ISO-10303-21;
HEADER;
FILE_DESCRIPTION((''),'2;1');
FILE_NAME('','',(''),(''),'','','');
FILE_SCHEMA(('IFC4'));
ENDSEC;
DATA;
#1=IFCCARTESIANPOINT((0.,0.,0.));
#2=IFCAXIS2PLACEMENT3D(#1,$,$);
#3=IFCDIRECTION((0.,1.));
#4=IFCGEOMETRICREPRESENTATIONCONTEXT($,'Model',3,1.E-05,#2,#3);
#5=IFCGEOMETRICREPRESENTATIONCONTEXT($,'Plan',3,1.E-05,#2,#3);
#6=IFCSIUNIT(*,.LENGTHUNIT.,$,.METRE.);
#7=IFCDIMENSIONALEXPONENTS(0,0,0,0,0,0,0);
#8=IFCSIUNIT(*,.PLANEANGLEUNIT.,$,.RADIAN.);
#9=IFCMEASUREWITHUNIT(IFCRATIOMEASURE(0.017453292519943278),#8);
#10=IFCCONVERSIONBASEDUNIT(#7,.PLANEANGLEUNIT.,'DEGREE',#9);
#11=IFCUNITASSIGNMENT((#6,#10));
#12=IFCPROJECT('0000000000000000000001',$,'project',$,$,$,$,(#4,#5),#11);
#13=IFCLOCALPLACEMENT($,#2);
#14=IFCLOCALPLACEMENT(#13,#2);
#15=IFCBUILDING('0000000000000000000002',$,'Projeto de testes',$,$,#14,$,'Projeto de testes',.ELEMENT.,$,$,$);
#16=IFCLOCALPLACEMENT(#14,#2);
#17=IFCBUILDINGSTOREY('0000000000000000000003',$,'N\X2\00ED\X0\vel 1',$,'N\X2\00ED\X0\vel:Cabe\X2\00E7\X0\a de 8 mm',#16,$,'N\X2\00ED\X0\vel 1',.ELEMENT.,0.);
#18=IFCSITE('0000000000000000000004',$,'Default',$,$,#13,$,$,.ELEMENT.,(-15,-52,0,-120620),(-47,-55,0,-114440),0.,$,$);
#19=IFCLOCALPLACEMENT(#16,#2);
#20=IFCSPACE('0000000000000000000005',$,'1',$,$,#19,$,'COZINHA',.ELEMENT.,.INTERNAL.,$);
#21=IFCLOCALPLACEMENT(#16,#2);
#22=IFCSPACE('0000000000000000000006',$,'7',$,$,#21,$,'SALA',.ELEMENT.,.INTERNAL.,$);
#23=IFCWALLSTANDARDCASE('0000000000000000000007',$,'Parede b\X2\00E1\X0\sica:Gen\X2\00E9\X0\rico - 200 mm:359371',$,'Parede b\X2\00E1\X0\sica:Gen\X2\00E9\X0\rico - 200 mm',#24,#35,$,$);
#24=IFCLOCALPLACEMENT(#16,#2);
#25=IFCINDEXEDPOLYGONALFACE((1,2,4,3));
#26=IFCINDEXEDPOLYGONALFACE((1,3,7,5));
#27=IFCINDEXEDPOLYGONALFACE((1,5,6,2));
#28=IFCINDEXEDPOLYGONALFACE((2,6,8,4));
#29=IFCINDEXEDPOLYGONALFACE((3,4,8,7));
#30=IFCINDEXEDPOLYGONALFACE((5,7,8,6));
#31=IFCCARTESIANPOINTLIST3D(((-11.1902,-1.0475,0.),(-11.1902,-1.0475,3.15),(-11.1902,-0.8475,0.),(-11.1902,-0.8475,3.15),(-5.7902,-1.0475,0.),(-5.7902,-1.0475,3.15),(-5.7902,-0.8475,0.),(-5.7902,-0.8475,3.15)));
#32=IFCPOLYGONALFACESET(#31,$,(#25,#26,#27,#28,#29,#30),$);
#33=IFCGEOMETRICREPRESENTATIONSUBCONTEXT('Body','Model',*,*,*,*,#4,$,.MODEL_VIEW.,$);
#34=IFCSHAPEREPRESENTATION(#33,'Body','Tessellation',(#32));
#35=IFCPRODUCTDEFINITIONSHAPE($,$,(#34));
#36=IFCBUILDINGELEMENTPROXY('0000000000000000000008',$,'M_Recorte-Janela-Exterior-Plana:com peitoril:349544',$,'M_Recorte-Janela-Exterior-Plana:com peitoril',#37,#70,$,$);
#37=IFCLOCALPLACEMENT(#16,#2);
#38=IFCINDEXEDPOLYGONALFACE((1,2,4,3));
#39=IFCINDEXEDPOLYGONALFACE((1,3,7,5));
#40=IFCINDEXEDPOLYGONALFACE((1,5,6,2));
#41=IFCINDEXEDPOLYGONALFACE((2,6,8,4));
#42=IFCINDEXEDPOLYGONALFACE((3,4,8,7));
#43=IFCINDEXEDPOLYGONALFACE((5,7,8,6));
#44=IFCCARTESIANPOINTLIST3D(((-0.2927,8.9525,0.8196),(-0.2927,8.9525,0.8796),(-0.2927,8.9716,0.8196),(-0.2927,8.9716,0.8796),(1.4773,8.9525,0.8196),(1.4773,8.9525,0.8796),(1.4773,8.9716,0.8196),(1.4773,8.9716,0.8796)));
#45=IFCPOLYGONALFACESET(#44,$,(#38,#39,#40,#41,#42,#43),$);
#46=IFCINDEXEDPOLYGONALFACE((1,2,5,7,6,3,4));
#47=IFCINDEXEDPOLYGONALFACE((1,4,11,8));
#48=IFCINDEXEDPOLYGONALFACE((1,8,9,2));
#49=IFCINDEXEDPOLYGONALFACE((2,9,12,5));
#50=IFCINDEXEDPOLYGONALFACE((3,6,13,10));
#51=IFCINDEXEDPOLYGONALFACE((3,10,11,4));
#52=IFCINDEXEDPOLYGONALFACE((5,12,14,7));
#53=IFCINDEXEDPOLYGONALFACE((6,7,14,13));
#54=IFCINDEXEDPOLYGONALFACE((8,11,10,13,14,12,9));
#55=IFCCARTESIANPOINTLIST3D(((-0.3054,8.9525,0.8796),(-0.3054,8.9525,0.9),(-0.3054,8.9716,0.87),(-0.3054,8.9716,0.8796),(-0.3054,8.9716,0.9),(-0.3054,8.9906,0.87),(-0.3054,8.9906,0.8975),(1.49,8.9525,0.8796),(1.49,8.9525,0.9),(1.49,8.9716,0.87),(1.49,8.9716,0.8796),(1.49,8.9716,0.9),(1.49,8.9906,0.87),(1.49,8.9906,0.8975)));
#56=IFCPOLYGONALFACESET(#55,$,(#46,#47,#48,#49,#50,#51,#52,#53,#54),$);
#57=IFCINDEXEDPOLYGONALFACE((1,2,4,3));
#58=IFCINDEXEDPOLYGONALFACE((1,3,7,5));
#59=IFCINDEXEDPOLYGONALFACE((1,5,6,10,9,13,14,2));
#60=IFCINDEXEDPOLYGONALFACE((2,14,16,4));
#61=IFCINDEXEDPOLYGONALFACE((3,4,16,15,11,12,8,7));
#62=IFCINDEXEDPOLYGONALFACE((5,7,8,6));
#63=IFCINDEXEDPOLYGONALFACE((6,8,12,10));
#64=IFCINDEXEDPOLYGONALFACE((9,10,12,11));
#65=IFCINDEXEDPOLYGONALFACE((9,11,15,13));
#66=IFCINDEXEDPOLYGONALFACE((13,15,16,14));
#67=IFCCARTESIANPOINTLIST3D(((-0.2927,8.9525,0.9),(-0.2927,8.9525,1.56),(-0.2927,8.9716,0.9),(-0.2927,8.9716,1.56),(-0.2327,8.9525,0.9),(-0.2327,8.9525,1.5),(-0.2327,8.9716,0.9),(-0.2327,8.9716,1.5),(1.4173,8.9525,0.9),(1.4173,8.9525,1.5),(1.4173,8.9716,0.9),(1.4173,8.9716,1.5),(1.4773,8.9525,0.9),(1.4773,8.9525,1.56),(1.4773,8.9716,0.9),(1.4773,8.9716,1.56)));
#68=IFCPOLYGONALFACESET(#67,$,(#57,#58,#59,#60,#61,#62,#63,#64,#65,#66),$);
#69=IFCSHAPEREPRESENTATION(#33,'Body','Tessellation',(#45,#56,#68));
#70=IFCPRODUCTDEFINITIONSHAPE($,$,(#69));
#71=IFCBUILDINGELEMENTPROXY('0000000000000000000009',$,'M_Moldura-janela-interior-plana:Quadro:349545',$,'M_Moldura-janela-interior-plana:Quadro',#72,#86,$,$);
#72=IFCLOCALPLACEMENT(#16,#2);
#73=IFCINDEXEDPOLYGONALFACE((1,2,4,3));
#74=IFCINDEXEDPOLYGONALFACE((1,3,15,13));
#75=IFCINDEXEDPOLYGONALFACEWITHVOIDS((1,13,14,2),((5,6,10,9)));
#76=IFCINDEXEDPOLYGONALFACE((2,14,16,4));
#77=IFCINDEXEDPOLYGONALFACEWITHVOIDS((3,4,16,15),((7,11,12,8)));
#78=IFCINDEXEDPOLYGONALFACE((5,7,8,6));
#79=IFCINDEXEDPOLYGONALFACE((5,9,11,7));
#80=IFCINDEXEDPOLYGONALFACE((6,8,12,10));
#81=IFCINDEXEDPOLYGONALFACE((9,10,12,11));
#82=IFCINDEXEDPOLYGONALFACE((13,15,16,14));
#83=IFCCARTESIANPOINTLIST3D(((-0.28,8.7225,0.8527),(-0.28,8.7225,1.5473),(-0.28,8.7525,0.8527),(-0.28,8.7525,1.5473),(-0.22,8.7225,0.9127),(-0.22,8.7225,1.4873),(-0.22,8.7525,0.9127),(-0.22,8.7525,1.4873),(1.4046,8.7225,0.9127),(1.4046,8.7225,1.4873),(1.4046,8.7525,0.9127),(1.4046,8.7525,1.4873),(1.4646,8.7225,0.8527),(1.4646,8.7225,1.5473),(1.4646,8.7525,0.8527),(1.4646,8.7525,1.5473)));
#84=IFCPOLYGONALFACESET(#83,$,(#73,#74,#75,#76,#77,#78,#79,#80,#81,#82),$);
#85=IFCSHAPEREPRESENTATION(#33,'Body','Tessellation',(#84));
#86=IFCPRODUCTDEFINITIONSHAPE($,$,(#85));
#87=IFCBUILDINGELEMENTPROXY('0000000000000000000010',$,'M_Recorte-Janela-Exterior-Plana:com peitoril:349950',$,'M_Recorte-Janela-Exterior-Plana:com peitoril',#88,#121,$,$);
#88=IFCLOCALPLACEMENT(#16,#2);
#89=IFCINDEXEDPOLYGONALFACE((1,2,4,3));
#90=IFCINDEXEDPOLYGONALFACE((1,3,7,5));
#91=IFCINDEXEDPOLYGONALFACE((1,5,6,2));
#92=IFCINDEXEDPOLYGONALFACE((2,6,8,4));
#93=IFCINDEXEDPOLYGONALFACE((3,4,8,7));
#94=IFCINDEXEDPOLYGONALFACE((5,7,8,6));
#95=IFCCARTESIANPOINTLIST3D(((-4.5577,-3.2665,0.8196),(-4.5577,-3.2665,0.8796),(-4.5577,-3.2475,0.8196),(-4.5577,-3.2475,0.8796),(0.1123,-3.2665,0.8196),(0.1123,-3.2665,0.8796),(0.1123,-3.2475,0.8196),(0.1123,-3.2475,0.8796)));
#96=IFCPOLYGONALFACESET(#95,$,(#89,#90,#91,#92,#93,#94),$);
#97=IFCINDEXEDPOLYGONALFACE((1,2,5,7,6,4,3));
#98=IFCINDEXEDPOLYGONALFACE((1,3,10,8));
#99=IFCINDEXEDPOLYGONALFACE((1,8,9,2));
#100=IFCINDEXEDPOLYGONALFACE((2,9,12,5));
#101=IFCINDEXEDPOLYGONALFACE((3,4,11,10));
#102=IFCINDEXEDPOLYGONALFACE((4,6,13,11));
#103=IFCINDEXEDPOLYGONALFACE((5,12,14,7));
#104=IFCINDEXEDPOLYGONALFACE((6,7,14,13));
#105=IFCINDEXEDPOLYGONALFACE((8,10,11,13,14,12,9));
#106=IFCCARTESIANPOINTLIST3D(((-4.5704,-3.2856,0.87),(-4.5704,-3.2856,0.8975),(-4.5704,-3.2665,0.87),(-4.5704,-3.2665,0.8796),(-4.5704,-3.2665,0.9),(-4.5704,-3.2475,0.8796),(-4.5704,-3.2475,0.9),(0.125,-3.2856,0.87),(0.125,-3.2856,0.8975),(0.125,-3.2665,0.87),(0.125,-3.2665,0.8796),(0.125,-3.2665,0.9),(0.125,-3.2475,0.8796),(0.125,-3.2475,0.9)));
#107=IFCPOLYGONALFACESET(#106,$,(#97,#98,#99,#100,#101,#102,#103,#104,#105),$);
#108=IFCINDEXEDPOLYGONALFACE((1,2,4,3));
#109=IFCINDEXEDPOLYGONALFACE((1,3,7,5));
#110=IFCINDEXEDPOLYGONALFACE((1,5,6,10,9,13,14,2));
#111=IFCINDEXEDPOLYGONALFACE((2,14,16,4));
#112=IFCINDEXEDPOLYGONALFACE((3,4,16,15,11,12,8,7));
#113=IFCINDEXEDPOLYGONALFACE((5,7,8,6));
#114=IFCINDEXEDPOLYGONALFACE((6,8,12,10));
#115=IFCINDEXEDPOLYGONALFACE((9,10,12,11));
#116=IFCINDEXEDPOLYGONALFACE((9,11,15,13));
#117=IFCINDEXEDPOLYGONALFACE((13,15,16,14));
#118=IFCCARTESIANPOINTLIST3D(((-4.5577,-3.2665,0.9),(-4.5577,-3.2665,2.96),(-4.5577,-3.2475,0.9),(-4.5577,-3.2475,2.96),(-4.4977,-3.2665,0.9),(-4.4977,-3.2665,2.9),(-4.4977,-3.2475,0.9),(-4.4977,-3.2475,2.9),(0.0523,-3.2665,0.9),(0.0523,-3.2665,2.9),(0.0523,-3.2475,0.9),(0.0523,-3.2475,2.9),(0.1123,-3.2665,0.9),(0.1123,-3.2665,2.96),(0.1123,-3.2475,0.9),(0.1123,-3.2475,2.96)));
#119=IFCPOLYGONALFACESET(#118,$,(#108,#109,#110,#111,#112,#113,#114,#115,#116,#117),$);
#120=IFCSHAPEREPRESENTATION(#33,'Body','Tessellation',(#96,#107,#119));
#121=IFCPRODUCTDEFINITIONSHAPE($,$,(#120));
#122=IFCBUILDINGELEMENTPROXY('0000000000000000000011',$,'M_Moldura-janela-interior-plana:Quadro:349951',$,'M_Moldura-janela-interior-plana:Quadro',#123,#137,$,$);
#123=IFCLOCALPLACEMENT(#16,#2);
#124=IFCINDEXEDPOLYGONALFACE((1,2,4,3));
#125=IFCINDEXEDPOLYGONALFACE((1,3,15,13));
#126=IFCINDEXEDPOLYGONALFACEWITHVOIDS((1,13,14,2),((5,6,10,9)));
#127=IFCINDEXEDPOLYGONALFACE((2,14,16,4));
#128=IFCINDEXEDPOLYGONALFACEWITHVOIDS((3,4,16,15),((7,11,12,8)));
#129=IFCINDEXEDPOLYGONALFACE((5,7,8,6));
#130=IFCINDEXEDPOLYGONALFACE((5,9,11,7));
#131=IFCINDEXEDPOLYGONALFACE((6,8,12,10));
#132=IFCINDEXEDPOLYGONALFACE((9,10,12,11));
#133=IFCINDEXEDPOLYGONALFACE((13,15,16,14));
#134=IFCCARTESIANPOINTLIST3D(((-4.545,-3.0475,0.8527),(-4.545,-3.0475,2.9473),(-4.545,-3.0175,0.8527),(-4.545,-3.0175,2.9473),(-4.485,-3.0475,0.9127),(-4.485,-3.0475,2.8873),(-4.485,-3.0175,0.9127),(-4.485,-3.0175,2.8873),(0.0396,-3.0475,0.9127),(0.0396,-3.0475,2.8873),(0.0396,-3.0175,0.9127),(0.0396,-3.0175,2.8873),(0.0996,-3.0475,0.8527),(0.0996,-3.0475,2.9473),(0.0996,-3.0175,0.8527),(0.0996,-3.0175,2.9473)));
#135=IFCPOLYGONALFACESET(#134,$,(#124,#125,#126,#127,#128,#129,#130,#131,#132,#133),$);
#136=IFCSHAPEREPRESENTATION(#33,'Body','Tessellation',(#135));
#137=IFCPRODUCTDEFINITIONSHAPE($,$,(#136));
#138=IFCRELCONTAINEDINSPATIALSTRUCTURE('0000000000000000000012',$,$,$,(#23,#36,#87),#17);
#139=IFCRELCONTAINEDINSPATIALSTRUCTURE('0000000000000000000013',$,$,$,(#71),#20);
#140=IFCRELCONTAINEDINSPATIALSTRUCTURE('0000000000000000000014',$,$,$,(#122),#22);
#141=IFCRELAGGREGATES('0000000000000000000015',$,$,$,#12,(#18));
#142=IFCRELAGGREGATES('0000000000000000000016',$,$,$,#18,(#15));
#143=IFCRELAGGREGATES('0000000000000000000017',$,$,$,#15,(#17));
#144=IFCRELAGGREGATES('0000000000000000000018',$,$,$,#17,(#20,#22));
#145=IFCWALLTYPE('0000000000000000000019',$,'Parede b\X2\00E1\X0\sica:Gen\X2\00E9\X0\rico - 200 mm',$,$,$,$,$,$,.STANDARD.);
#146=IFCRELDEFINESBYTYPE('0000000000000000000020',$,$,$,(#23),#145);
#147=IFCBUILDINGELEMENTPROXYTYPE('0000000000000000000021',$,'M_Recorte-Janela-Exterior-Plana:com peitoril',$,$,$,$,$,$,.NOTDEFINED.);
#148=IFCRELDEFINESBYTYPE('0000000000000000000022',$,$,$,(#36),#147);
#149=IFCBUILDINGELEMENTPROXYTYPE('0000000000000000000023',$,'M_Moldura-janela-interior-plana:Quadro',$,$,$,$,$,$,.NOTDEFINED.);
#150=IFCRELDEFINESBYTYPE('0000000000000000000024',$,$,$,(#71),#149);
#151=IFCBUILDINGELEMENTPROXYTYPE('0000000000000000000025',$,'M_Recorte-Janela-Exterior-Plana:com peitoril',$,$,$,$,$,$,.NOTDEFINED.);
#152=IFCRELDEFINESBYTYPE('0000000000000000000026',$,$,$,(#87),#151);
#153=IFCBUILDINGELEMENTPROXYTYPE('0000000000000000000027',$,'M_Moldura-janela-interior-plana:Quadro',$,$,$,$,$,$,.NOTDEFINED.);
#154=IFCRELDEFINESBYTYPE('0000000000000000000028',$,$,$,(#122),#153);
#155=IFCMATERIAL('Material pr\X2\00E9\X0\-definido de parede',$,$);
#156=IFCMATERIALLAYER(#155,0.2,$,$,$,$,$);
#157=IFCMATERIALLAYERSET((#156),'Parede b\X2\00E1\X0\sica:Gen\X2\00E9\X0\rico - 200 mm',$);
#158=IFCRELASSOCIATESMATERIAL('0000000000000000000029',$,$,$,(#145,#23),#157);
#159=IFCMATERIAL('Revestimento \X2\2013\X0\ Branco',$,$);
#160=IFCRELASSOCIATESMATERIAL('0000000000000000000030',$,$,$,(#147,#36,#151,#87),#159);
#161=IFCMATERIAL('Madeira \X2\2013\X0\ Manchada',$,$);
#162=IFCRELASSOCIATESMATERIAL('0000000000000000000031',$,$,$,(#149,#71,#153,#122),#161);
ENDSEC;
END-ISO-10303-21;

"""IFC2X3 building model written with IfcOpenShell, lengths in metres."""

from ifc_helpers import new_model, entity, si_unit, converted_unit, direction, frame, frame_2d, origin, place, context, subcontext, project, spatial, polyline, rectangle, outline, extrude, source, transform, mapped, material, layer, layer_set, layer_usage, type_object, type_shapes, element, save


model = new_model("IFC2X3")

# Units and contexts
model_context = context("Model", 3, precision=1e-05, world=origin(), true_north=direction((0.0, 1.0)))
plan_context = context("Plan", 3, precision=1e-05, world=origin(), true_north=direction((0.0, 1.0)))
body_context = subcontext(model_context, "Body", "Model", "MODEL_VIEW")
ifc_project = project(units=[si_unit("LENGTHUNIT", "METRE"), converted_unit("PLANEANGLEUNIT", "DEGREE", entity("IfcRatioMeasure", 0.017453292519943278), si_unit("PLANEANGLEUNIT", "RADIAN"), dimensions=[0, 0, 0, 0, 0, 0, 0])], contexts=[model_context, plan_context])

# Site, building, storey
site_placement = place(None, origin())
site = spatial("IfcSite", under=ifc_project, at=site_placement, Name="Default", CompositionType="ELEMENT", RefLatitude=(-15, -52, 0, -120620), RefLongitude=(-47, -55, 0, -114440), RefElevation=0.0)
building_placement = place(site_placement, origin())
building = spatial("IfcBuilding", under=site, at=building_placement, Name="Projeto de testes", LongName="Projeto de testes", CompositionType="ELEMENT")
storey_placement = place(building_placement, origin())
storey = spatial("IfcBuildingStorey", under=building, at=storey_placement, Name="Nível 1", ObjectType="Nível:Cabeça de 8 mm", LongName="Nível 1", CompositionType="ELEMENT", Elevation=0.0)

# Shared definitions
ifc_material_1 = material(Name="Material pré-definido de parede")
ifc_layer_1 = layer(ifc_material_1, 0.2)
ifc_layer_set_1 = layer_set([ifc_layer_1], Name="Parede básica:Genérico - 200 mm")
wall_type = type_object("IfcWallType", Name="Parede básica:Genérico - 200 mm", PredefinedType="STANDARD", material=ifc_layer_set_1)

# Shared definitions
ifc_layer_usage_1 = layer_usage(ifc_layer_set_1, "AXIS2", "NEGATIVE", 0.1)

# Wall
wall_1_placement = place(storey_placement, frame((-11.1902, -0.9475, 0.0)))
element("IfcWallStandardCase", 1, at=wall_1_placement, inside=storey, type_object=wall_type, material=ifc_layer_usage_1, Name="Parede básica:Genérico - 200 mm:359371", ObjectType="Parede básica:Genérico - 200 mm", context=body_context, shape_type="SweptSolid", body=[
    extrude(rectangle(XDim=5.4, YDim=0.2, at=frame_2d((2.7, 0.0), x_axis=(-1.0, 0.0))), origin(), (0.0, 0.0, 1.0), 3.15),
])

# Building element proxy
ifc_material_2 = material(Name="Revestimento – Branco")
building_element_proxy_type_1 = type_object("IfcBuildingElementProxyType", Name="M_Recorte-Janela-Exterior-Plana:com peitoril", PredefinedType="NOTDEFINED", material=ifc_material_2)
shared_shape_1 = source(origin(), body_context, "Body", "SweptSolid", [
    extrude(rectangle(XDim=0.06, YDim=1.77, at=frame_2d((0.0, 0.0), x_axis=(1.0, 0.0))), frame((0.0, 0.6504, 0.0), z_axis=(0.0, 0.0, 1.0), x_axis=(0.0, 1.0, 0.0)), (0.0, 0.0, 1.0), 0.019),
    extrude(outline(polyline([(-0.0152, -0.019), (0.0123, -0.019), (0.0148, 0.0), (0.0148, 0.019), (-0.0057, 0.019), (-0.0057, 0.0), (-0.0152, 0.0), (-0.0152, -0.019)])), frame((-0.8977, 0.6148, 0.019), z_axis=(1.0, 0.0, 0.0), x_axis=(0.0, -1.0, 0.0)), (0.0, 0.0, 1.0), 1.7954),
    extrude(outline(polyline([(-0.885, -0.345), (0.885, -0.345), (0.885, 0.315), (0.825, 0.315), (0.825, -0.285), (-0.825, -0.285), (-0.825, 0.315), (-0.885, 0.315), (-0.885, -0.345)])), frame((0.0, 0.285, 0.0)), (0.0, 0.0, 1.0), 0.019),
])
type_shapes(building_element_proxy_type_1, [shared_shape_1])
proxy_1_placement = place(storey_placement, frame((0.5923, 8.9525, 1.5), z_axis=(0.0, 1.0, 0.0), x_axis=(1.0, 0.0, 0.0)))
element("IfcBuildingElementProxy", 2, at=proxy_1_placement, inside=storey, type_object=building_element_proxy_type_1, material=ifc_material_2, Name="M_Recorte-Janela-Exterior-Plana:com peitoril:349544", ObjectType="M_Recorte-Janela-Exterior-Plana:com peitoril", context=body_context, shape_type="MappedRepresentation", body=[
    mapped(shared_shape_1, transform((0.0, 0.0, 0.0), scale=1.0)),
])

# Shared definitions
space_1_placement = place(storey_placement, origin())
space_1 = spatial("IfcSpace", under=storey, at=space_1_placement, Name="1", LongName="COZINHA", CompositionType="ELEMENT", InteriorOrExteriorSpace="INTERNAL")

# Building element proxies
ifc_material_3 = material(Name="Madeira – Manchada")
building_element_proxy_type_2 = type_object("IfcBuildingElementProxyType", Name="M_Moldura-janela-interior-plana:Quadro", PredefinedType="NOTDEFINED", material=ifc_material_3)
shared_shape_2 = source(origin(), body_context, "Body", "SweptSolid", [
    extrude(outline(polyline([(-0.3473, -0.8723), (0.3473, -0.8723), (0.3473, 0.8723), (-0.3473, 0.8723), (-0.3473, -0.8723)]), holes=[polyline([(-0.2873, -0.8123), (-0.2873, 0.8123), (0.2873, 0.8123), (0.2873, -0.8123), (-0.2873, -0.8123)])]), frame((0.0, 0.3, 0.0), z_axis=(0.0, 0.0, 1.0), x_axis=(0.0, 1.0, 0.0)), (0.0, 0.0, 1.0), 0.03),
])
type_shapes(building_element_proxy_type_2, [shared_shape_2])
proxy_2_placement = place(space_1_placement, frame((0.5923, 8.7525, 1.5), z_axis=(0.0, -1.0, 0.0), x_axis=(-1.0, 0.0, 0.0)))
element("IfcBuildingElementProxy", 3, at=proxy_2_placement, inside=space_1, type_object=building_element_proxy_type_2, material=ifc_material_3, Name="M_Moldura-janela-interior-plana:Quadro:349545", ObjectType="M_Moldura-janela-interior-plana:Quadro", context=body_context, shape_type="MappedRepresentation", body=[
    mapped(shared_shape_2, transform((0.0, 0.0, 0.0), scale=1.0)),
])
building_element_proxy_type_3 = type_object("IfcBuildingElementProxyType", Name="M_Recorte-Janela-Exterior-Plana:com peitoril", PredefinedType="NOTDEFINED", material=ifc_material_2)
shared_shape_3 = source(origin(), body_context, "Body", "SweptSolid", [
    extrude(rectangle(XDim=4.67, YDim=0.06, at=frame_2d((0.0, 0.0), x_axis=(1.0, 0.0))), frame((0.0, -2.0504, 0.0), z_axis=(0.0, 0.0, 1.0), x_axis=(-1.0, 0.0, 0.0)), (0.0, 0.0, 1.0), 0.019),
    extrude(outline(polyline([(-0.019, -0.0152), (0.0, -0.0152), (0.0, -0.0057), (0.019, -0.0057), (0.019, 0.0148), (0.0, 0.0148), (-0.019, 0.0123), (-0.019, -0.0152)])), frame((-2.3477, -2.0148, 0.019), z_axis=(1.0, 0.0, 0.0), x_axis=(0.0, 0.0, -1.0)), (0.0, 0.0, 1.0), 4.6954),
    extrude(outline(polyline([(-1.045, -2.335), (1.015, -2.335), (1.015, -2.275), (-0.985, -2.275), (-0.985, 2.275), (1.015, 2.275), (1.015, 2.335), (-1.045, 2.335), (-1.045, -2.335)])), frame((0.0, -0.985, 0.0), z_axis=(0.0, 0.0, 1.0), x_axis=(0.0, -1.0, 0.0)), (0.0, 0.0, 1.0), 0.019),
])
type_shapes(building_element_proxy_type_3, [shared_shape_3])
proxy_3_placement = place(storey_placement, frame((-2.2227, -3.2475, 2.9), z_axis=(0.0, -1.0, 0.0), x_axis=(1.0, 0.0, 0.0)))
element("IfcBuildingElementProxy", 4, at=proxy_3_placement, inside=storey, type_object=building_element_proxy_type_3, material=ifc_material_2, Name="M_Recorte-Janela-Exterior-Plana:com peitoril:349950", ObjectType="M_Recorte-Janela-Exterior-Plana:com peitoril", context=body_context, shape_type="MappedRepresentation", body=[
    mapped(shared_shape_3, transform((0.0, 0.0, 0.0), scale=1.0)),
])

# Shared definitions
space_2_placement = place(storey_placement, origin())
space_2 = spatial("IfcSpace", under=storey, at=space_2_placement, Name="7", LongName="SALA", CompositionType="ELEMENT", InteriorOrExteriorSpace="INTERNAL")

# Building element proxy
building_element_proxy_type_4 = type_object("IfcBuildingElementProxyType", Name="M_Moldura-janela-interior-plana:Quadro", PredefinedType="NOTDEFINED", material=ifc_material_3)
shared_shape_4 = source(origin(), body_context, "Body", "SweptSolid", [
    extrude(outline(polyline([(-2.3223, -1.0473), (2.3223, -1.0473), (2.3223, 1.0473), (-2.3223, 1.0473), (-2.3223, -1.0473)]), holes=[polyline([(-2.2623, -0.9873), (-2.2623, 0.9873), (2.2623, 0.9873), (2.2623, -0.9873), (-2.2623, -0.9873)])]), frame((0.0, -1.0, 0.0), z_axis=(0.0, 0.0, 1.0), x_axis=(-1.0, 0.0, 0.0)), (0.0, 0.0, 1.0), 0.03),
])
type_shapes(building_element_proxy_type_4, [shared_shape_4])
proxy_4_placement = place(space_2_placement, frame((-2.2227, -3.0475, 2.9), z_axis=(0.0, 1.0, 0.0), x_axis=(-1.0, 0.0, 0.0)))
element("IfcBuildingElementProxy", 5, at=proxy_4_placement, inside=space_2, type_object=building_element_proxy_type_4, material=ifc_material_3, Name="M_Moldura-janela-interior-plana:Quadro:349951", ObjectType="M_Moldura-janela-interior-plana:Quadro", context=body_context, shape_type="MappedRepresentation", body=[
    mapped(shared_shape_4, transform((0.0, 0.0, 0.0), scale=1.0)),
])

save(model, "model.ifc")
